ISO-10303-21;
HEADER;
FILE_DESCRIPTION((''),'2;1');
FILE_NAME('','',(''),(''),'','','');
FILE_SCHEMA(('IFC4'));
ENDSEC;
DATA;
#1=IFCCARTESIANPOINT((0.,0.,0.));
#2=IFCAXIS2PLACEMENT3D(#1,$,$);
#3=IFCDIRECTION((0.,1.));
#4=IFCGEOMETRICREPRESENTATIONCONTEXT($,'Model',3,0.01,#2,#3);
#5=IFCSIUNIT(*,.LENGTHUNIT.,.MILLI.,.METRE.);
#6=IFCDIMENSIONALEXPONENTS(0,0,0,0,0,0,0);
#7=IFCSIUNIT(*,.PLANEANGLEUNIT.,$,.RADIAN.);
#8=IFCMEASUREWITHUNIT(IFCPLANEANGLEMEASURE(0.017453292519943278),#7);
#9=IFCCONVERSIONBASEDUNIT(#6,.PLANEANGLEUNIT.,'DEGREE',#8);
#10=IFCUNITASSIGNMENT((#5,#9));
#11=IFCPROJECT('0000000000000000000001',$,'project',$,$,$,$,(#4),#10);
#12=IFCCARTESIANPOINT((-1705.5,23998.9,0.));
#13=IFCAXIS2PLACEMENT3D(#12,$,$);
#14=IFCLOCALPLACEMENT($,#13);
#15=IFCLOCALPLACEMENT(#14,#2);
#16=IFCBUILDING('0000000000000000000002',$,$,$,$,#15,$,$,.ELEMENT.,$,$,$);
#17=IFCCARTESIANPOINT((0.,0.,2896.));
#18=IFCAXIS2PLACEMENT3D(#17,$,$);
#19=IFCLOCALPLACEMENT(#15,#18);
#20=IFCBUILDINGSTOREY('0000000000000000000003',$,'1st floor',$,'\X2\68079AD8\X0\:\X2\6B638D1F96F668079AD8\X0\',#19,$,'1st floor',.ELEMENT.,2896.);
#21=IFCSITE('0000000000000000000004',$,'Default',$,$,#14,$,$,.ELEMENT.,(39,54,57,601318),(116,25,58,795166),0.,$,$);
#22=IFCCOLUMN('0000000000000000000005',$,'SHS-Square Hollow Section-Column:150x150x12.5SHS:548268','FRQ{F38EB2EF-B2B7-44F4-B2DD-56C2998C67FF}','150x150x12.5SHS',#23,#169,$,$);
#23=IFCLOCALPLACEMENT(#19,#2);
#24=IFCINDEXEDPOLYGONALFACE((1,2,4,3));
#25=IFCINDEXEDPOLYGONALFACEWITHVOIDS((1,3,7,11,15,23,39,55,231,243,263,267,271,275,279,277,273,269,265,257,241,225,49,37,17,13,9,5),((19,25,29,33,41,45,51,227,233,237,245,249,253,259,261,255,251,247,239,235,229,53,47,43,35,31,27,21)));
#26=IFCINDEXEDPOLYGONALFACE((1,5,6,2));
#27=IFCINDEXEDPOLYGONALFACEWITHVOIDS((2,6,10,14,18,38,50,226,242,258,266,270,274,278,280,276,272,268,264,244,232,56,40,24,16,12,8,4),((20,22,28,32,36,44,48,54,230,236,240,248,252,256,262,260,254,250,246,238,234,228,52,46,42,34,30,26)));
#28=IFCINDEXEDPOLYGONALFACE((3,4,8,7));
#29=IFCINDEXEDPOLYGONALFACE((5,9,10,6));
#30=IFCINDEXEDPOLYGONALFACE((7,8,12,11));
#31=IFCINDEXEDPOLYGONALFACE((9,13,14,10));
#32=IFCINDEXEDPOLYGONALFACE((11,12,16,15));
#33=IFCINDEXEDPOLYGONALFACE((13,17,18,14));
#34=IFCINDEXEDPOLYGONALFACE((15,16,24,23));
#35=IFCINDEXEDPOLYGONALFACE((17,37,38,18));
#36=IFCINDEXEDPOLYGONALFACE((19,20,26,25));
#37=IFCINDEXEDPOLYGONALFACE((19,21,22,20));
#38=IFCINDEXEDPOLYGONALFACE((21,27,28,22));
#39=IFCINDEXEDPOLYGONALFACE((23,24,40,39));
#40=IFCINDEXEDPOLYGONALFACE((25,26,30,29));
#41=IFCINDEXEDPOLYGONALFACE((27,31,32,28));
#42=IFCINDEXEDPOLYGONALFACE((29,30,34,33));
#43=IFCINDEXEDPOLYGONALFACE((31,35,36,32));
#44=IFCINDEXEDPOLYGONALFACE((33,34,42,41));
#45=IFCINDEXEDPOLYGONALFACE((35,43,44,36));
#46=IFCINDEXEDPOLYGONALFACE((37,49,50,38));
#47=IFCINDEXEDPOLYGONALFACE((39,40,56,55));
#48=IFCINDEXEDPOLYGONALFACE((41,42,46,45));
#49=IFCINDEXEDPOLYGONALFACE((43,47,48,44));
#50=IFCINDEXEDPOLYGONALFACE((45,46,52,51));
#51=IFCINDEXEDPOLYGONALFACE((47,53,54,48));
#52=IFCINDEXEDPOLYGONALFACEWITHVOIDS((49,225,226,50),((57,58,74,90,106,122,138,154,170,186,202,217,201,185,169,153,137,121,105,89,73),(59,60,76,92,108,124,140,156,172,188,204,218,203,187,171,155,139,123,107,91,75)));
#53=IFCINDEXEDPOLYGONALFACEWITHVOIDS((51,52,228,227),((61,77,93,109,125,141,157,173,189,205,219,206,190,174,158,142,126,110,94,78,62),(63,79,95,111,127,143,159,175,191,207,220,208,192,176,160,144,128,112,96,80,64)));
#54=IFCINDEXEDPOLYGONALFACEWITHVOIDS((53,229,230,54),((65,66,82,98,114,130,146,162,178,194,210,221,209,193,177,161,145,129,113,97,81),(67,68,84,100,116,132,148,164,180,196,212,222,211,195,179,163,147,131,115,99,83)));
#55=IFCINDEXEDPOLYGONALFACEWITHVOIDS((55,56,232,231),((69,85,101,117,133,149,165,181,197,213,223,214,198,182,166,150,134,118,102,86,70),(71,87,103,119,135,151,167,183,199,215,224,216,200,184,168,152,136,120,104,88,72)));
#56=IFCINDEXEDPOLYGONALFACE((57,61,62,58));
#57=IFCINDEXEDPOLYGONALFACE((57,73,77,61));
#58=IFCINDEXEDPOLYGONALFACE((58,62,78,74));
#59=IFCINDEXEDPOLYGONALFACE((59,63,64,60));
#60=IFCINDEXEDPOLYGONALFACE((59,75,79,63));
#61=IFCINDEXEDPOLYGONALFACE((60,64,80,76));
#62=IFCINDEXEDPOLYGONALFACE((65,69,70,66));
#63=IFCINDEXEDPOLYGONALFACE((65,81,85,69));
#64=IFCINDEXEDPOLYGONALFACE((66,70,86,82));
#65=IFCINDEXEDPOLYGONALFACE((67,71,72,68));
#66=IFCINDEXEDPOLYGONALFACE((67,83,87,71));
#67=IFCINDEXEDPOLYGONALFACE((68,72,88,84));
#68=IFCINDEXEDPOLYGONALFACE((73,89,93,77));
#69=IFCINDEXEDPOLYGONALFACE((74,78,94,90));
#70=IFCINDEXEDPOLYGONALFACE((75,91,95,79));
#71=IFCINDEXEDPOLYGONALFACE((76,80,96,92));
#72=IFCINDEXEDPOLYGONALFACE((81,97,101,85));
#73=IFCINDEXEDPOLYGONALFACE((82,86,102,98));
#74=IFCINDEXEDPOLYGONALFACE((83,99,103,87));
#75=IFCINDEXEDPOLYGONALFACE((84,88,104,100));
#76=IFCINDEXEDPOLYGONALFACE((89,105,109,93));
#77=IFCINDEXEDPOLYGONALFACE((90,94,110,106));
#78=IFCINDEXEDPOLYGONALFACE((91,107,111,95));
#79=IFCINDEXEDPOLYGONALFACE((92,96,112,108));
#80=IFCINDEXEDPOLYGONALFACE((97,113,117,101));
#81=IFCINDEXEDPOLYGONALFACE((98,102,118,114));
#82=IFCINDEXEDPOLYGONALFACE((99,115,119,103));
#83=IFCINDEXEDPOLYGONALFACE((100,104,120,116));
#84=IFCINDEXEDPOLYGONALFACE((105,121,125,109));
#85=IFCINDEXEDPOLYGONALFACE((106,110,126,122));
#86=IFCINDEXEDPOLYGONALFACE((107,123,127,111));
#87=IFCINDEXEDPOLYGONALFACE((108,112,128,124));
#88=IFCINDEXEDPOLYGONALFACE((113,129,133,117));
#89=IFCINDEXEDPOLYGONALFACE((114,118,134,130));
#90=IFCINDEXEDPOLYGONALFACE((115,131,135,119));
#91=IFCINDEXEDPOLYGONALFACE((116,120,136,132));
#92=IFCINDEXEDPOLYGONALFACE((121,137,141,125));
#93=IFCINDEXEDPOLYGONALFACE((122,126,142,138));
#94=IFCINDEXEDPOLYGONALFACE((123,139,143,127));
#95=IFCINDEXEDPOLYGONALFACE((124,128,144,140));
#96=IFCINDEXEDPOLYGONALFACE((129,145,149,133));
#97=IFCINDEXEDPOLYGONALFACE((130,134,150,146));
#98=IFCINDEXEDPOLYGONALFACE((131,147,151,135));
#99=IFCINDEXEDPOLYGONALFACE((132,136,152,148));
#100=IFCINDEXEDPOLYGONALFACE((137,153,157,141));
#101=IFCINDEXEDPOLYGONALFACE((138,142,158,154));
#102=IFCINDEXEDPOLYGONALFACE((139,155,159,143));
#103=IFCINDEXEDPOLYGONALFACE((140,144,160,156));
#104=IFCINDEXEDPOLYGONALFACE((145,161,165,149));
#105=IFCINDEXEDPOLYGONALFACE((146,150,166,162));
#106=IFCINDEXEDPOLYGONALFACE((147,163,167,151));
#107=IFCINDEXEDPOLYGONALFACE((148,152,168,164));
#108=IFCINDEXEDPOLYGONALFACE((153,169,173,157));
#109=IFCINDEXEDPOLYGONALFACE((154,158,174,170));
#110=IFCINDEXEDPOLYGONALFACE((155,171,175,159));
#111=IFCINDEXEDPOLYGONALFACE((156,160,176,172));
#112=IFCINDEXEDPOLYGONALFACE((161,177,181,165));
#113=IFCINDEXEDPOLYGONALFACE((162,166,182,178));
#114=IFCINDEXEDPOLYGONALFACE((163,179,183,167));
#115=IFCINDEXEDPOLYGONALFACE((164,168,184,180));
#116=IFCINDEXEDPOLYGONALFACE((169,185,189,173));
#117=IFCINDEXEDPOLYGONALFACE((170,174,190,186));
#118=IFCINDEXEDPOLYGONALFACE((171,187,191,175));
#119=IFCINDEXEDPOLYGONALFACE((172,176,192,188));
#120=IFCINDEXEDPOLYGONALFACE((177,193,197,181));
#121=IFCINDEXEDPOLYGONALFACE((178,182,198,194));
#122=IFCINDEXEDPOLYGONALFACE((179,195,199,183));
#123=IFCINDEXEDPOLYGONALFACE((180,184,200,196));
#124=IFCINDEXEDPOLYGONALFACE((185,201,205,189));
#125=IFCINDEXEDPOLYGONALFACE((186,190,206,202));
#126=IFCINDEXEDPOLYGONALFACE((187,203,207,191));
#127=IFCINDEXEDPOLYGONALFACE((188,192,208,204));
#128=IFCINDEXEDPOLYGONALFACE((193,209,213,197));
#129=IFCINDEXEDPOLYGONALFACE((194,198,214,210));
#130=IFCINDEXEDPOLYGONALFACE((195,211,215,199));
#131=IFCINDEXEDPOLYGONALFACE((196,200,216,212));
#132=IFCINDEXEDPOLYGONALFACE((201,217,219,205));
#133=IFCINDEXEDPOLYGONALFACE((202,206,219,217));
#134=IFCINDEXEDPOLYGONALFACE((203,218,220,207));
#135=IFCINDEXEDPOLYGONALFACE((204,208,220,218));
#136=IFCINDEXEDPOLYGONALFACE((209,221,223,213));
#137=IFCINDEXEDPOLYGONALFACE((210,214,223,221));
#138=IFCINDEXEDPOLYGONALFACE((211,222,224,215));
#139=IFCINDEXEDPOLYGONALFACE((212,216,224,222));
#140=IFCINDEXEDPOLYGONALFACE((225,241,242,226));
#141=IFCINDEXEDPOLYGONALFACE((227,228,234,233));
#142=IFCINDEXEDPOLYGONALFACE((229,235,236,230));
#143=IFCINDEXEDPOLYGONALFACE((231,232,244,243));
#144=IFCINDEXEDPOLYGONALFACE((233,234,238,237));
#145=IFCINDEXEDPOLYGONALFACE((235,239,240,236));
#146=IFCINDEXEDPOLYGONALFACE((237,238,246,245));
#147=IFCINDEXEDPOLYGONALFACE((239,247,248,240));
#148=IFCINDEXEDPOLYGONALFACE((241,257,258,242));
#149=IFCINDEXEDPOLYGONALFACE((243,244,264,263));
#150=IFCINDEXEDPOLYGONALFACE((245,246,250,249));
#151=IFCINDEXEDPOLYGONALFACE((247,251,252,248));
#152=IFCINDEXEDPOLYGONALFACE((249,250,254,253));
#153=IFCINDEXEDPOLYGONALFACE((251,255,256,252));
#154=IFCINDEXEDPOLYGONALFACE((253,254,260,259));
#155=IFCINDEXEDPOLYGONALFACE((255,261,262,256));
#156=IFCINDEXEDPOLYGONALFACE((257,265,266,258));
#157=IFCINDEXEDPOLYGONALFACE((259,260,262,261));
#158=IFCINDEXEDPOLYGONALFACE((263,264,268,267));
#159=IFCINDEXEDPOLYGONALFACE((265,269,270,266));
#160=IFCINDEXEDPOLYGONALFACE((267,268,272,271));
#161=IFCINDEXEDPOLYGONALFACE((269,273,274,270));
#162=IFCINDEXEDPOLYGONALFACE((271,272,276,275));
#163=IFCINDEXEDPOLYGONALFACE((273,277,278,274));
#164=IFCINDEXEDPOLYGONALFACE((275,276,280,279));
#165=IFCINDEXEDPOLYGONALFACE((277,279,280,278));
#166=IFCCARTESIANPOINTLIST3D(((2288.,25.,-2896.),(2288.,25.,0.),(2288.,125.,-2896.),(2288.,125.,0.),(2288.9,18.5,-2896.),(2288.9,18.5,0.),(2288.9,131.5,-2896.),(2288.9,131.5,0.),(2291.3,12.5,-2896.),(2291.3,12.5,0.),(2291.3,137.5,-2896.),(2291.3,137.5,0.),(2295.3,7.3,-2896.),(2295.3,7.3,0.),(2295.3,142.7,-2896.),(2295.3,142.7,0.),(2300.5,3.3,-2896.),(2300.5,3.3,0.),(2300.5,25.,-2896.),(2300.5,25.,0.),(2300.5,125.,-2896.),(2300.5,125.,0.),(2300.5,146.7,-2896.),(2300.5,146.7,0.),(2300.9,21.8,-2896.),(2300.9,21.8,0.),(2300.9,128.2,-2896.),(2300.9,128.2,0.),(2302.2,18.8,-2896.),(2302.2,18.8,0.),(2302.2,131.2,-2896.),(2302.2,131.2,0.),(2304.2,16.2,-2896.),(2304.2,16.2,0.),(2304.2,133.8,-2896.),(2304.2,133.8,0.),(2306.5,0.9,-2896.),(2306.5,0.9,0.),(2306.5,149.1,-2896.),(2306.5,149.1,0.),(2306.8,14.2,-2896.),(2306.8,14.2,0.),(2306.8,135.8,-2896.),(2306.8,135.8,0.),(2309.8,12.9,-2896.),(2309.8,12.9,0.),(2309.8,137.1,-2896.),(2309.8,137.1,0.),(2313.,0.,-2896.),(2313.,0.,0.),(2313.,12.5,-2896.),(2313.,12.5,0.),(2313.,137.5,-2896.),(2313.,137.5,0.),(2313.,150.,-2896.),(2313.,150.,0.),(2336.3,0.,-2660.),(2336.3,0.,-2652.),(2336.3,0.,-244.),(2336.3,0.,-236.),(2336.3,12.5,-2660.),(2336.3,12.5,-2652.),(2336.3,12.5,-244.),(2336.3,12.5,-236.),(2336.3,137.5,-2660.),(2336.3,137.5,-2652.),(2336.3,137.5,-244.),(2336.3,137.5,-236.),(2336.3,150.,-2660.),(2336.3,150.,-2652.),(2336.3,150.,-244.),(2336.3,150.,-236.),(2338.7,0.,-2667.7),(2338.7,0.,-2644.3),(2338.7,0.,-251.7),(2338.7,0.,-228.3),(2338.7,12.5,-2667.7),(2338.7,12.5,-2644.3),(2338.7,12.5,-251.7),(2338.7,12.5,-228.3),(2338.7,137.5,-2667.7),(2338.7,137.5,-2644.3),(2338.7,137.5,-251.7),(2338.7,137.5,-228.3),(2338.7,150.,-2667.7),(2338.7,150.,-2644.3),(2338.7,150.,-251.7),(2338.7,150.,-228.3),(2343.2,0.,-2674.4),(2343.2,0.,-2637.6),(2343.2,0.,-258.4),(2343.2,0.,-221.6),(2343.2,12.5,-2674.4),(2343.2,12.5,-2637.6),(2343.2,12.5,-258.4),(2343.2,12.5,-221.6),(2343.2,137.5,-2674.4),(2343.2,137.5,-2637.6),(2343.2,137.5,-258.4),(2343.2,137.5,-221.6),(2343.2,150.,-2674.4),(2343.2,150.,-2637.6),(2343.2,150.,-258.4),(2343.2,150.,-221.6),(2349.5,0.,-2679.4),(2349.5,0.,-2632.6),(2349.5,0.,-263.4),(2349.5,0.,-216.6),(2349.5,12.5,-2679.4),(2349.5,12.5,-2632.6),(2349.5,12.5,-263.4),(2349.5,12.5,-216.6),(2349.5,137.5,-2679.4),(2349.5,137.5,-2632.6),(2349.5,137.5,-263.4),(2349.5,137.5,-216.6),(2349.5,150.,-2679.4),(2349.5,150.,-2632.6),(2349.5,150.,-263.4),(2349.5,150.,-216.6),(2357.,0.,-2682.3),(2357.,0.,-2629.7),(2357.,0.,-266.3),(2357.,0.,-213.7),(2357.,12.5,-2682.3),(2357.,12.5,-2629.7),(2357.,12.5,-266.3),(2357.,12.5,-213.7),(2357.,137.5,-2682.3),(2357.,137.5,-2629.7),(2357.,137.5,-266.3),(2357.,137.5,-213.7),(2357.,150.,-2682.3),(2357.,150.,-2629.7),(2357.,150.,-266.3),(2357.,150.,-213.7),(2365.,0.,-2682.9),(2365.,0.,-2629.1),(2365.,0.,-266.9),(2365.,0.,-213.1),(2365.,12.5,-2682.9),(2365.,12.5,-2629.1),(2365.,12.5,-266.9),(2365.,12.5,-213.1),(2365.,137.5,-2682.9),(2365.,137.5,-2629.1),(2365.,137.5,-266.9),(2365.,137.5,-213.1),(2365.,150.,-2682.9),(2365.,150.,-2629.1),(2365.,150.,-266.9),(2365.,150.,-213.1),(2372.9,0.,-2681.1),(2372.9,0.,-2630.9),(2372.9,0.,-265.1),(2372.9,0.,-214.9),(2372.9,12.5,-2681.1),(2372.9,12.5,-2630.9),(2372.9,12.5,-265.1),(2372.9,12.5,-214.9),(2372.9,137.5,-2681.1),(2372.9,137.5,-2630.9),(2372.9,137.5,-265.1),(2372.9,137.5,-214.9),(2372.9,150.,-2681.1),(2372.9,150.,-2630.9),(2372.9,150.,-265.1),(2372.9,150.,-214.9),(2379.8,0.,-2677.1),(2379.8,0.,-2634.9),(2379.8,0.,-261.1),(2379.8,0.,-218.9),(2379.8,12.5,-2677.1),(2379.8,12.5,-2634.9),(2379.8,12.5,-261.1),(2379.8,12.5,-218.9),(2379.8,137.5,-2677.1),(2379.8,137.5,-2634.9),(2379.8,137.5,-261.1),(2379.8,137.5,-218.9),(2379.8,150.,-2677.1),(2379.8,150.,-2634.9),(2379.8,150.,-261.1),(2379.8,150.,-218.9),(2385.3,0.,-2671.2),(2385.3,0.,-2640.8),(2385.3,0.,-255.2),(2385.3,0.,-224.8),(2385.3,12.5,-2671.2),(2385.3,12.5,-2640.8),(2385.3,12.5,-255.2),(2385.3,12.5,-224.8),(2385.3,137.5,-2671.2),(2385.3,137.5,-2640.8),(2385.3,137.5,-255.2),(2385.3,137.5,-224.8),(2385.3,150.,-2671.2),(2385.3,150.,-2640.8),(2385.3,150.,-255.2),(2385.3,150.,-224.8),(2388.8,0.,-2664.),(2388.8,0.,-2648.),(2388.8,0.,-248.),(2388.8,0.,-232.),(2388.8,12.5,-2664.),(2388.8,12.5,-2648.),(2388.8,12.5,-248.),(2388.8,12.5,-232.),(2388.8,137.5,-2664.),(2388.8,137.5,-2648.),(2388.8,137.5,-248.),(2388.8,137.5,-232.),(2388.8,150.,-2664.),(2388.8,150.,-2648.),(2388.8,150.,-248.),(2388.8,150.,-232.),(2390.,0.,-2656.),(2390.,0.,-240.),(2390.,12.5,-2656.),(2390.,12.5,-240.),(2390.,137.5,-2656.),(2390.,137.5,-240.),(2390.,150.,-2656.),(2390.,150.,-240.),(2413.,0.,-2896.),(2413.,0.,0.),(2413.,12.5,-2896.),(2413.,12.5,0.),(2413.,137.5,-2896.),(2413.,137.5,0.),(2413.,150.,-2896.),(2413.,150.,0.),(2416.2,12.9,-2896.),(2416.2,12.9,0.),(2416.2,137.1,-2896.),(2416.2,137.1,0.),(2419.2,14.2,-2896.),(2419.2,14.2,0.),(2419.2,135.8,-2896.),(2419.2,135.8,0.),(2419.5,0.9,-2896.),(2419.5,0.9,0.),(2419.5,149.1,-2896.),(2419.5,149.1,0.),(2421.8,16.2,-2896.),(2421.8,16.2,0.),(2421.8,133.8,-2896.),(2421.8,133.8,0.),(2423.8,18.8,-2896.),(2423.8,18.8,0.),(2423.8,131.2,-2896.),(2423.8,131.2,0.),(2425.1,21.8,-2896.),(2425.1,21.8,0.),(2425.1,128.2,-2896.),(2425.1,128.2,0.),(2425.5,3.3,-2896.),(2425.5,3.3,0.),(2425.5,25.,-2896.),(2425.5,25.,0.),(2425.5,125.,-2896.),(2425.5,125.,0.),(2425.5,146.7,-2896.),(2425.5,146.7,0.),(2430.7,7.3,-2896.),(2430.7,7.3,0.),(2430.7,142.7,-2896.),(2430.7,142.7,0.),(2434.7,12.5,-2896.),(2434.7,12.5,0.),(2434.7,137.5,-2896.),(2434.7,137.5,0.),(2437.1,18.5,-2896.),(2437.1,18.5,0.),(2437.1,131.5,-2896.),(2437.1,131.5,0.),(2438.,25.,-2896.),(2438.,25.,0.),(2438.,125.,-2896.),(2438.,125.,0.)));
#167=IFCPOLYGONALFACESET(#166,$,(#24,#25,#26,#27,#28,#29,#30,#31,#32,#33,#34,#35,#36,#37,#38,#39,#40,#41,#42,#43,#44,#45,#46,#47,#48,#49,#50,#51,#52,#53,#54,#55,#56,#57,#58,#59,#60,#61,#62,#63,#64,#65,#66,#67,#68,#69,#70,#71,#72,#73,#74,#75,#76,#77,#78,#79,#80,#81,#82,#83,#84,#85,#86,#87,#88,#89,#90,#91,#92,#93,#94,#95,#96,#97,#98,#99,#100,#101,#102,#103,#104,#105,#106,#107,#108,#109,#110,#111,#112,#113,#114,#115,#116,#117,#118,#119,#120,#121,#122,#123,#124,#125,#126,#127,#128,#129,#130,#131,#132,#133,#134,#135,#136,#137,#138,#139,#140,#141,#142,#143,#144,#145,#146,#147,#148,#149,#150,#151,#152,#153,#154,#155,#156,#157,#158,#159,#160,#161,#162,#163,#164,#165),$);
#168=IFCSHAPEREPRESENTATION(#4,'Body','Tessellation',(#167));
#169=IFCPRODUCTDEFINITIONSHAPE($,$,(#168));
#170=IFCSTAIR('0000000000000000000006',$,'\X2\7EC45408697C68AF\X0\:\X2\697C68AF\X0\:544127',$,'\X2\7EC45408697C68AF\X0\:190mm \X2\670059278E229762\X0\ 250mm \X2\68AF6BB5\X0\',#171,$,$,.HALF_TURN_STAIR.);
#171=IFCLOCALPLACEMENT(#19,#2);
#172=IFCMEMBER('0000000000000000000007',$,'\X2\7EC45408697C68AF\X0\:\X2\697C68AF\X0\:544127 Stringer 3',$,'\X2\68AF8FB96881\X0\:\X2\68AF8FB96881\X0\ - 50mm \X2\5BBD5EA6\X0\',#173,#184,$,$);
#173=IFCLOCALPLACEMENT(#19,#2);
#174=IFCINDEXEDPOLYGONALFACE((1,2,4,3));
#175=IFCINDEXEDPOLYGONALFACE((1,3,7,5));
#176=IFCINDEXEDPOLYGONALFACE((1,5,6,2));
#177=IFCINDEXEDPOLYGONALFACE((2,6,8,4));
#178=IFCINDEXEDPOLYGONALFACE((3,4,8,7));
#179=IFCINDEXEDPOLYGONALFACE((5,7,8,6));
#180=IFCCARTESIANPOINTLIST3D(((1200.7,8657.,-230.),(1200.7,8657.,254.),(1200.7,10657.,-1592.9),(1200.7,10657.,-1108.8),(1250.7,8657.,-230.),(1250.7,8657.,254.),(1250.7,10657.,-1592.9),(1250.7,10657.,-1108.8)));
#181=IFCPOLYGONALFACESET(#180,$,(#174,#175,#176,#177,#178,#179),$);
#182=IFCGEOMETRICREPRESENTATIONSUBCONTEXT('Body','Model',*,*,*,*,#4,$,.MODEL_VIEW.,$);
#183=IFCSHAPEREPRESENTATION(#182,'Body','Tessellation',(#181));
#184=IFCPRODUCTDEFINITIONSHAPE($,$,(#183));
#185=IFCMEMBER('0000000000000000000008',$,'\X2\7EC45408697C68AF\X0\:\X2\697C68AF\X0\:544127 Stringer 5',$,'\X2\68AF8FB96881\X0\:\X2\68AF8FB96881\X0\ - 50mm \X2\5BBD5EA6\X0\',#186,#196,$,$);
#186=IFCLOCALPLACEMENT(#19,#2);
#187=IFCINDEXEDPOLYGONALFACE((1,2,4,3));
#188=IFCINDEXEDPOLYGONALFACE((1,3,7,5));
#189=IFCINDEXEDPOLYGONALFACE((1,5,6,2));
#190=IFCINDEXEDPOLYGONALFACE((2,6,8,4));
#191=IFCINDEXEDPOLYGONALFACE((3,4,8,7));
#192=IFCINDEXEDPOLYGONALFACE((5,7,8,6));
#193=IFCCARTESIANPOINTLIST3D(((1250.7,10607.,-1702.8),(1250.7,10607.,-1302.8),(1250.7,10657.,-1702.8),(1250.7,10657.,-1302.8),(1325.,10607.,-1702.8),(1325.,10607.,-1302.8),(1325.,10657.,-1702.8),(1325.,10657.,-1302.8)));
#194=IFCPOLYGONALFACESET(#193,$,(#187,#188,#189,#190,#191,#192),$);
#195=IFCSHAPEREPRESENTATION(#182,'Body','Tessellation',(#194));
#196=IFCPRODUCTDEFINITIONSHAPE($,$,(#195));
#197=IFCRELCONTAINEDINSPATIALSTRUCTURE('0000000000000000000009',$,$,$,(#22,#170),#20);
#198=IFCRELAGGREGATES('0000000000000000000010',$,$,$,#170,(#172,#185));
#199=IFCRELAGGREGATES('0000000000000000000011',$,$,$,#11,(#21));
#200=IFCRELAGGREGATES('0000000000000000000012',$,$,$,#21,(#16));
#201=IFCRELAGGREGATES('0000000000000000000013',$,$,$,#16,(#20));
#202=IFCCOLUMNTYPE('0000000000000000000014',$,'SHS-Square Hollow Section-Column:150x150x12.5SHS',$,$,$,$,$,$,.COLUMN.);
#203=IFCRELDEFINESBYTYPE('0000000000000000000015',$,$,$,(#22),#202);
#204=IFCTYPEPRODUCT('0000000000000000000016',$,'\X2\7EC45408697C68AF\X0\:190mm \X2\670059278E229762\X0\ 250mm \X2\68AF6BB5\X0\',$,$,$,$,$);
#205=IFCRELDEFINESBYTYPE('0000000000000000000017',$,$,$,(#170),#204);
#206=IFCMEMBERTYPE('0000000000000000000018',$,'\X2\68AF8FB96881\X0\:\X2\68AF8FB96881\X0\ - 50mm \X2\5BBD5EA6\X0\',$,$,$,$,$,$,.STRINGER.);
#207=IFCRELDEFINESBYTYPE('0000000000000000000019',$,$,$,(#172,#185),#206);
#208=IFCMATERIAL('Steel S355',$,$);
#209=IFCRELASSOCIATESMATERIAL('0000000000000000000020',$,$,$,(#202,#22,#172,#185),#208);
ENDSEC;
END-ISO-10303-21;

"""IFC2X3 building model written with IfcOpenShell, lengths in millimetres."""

from ifc_helpers import new_model, entity, si_unit, converted_unit, direction, frame, frame_2d, origin, origin_2d, origin_2d_with_axis, place, context, subcontext, project, spatial, polyline, circle_curve, rectangle, hollow_rectangle, outline, extrude, material, type_object, element, aggregate, save


model = new_model("IFC2X3")

# Units and contexts
model_context = context("Model", 3, precision=0.01, world=origin(), true_north=direction((0.0, 1.0)))
body_context = subcontext(model_context, "Body", "Model", "MODEL_VIEW")
ifc_project = project(units=[si_unit("LENGTHUNIT", "METRE", prefix="MILLI"), converted_unit("PLANEANGLEUNIT", "DEGREE", entity("IfcPlaneAngleMeasure", 0.017453292519943278), si_unit("PLANEANGLEUNIT", "RADIAN"), dimensions=[0, 0, 0, 0, 0, 0, 0])], contexts=[model_context])

# Site, building, storey
site_placement = place(None, frame((-1705.5, 23998.9, 0.0)))
site = spatial("IfcSite", under=ifc_project, at=site_placement, Name="Default", CompositionType="ELEMENT", RefLatitude=(39, 54, 57, 601318), RefLongitude=(116, 25, 58, 795166), RefElevation=0.0)
building_placement = place(site_placement, origin())
building = spatial("IfcBuilding", under=site, at=building_placement, CompositionType="ELEMENT")
storey_placement = place(building_placement, frame((0.0, 0.0, 2896.0)))
storey = spatial("IfcBuildingStorey", under=building, at=storey_placement, Name="1st floor", ObjectType="标高:正负零标高", LongName="1st floor", CompositionType="ELEMENT", Elevation=2896.0)

# Column, openings
ifc_material_1 = material(Name="Steel S355")
column_type = type_object("IfcColumnType", Name="SHS-Square Hollow Section-Column:150x150x12.5SHS", PredefinedType="COLUMN", material=ifc_material_1)
column_1_placement = place(storey_placement, frame((2363.0, 75.0, 0.0), z_axis=(0.0, 0.0, 1.0), x_axis=(0.0, -1.0, 0.0)))
column_1 = element("IfcColumn", 1, at=column_1_placement, inside=storey, type_object=column_type, material=ifc_material_1, Name="SHS-Square Hollow Section-Column:150x150x12.5SHS:548268", Description="FRQ{F38EB2EF-B2B7-44F4-B2DD-56C2998C67FF}", ObjectType="150x150x12.5SHS", context=model_context, shape_type="SweptSolid", body=[
    extrude(hollow_rectangle(XDim=150.0, YDim=150.0, WallThickness=12.5, InnerFilletRadius=12.5, OuterFilletRadius=25.0, at=origin_2d()), origin(), (0.0, 0.0, -1.0), 2896.0),
])
opening_1_placement = place(column_1_placement, frame((-175.1, 0.0, -2896.0), z_axis=(1.0, 0.0, 0.0), x_axis=(0.0, 1.0, 0.0)))
element("IfcOpeningElement", 2, at=opening_1_placement, cuts=column_1, ObjectType="Opening", context=model_context, shape_type="SweptSolid", body=[
    extrude(outline(circle_curve(frame_2d((0.0, 240.0), x_axis=(1.0, 0.0)), 27.0)), origin(), (0.0, 0.0, 1.0), 350.2),
])
opening_2_placement = place(column_1_placement, frame((-175.1, 0.0, 0.0), z_axis=(1.0, 0.0, 0.0), x_axis=(0.0, 1.0, 0.0)))
element("IfcOpeningElement", 3, at=opening_2_placement, cuts=column_1, ObjectType="Opening", context=model_context, shape_type="SweptSolid", body=[
    extrude(outline(circle_curve(frame_2d((0.0, -240.0), x_axis=(1.0, 0.0)), 27.0)), origin(), (0.0, 0.0, 1.0), 350.2),
])

# Stair, members
type_product = type_object("IfcTypeProduct", Name="组合楼梯:190mm 最大踢面 250mm 梯段")
stair_placement = place(storey_placement, origin())
stair = element("IfcStair", 4, at=stair_placement, inside=storey, type_object=type_product, Name="组合楼梯:楼梯:544127", ObjectType="组合楼梯:190mm 最大踢面 250mm 梯段", ShapeType="HALF_TURN_STAIR")
member_type = type_object("IfcMemberType", Name="梯边梁:梯边梁 - 50mm 宽度", PredefinedType="STRINGER")
member_1_placement = place(stair_placement, origin())
member_1 = element("IfcMember", 5, at=member_1_placement, type_object=member_type, material=ifc_material_1, Name="组合楼梯:楼梯:544127 Stringer 3", ObjectType="梯边梁:梯边梁 - 50mm 宽度", context=body_context, shape_type="SweptSolid", body=[
    extrude(outline(polyline([(-1073.8, -200.0), (1346.4, -200.0), (1073.8, 200.0), (-1346.4, 200.0), (-1073.8, -200.0)])), frame((1200.7, 9657.0, -669.4), z_axis=(1.0, 0.0, 0.0), x_axis=(0.0, -0.826384, 0.563108)), (0.0, 0.0, 1.0), 50.0),
])
member_2_placement = place(stair_placement, origin())
member_2 = element("IfcMember", 6, at=member_2_placement, type_object=member_type, material=ifc_material_1, Name="组合楼梯:楼梯:544127 Stringer 5", ObjectType="梯边梁:梯边梁 - 50mm 宽度", context=body_context, shape_type="SweptSolid", body=[
    extrude(rectangle(XDim=74.3, YDim=50.0, at=origin_2d_with_axis()), frame((1287.9, 10632.0, -1702.8)), (0.0, 0.0, 1.0), 400.0),
])

aggregate(stair, [member_1, member_2])

save(model, "model.ifc")
